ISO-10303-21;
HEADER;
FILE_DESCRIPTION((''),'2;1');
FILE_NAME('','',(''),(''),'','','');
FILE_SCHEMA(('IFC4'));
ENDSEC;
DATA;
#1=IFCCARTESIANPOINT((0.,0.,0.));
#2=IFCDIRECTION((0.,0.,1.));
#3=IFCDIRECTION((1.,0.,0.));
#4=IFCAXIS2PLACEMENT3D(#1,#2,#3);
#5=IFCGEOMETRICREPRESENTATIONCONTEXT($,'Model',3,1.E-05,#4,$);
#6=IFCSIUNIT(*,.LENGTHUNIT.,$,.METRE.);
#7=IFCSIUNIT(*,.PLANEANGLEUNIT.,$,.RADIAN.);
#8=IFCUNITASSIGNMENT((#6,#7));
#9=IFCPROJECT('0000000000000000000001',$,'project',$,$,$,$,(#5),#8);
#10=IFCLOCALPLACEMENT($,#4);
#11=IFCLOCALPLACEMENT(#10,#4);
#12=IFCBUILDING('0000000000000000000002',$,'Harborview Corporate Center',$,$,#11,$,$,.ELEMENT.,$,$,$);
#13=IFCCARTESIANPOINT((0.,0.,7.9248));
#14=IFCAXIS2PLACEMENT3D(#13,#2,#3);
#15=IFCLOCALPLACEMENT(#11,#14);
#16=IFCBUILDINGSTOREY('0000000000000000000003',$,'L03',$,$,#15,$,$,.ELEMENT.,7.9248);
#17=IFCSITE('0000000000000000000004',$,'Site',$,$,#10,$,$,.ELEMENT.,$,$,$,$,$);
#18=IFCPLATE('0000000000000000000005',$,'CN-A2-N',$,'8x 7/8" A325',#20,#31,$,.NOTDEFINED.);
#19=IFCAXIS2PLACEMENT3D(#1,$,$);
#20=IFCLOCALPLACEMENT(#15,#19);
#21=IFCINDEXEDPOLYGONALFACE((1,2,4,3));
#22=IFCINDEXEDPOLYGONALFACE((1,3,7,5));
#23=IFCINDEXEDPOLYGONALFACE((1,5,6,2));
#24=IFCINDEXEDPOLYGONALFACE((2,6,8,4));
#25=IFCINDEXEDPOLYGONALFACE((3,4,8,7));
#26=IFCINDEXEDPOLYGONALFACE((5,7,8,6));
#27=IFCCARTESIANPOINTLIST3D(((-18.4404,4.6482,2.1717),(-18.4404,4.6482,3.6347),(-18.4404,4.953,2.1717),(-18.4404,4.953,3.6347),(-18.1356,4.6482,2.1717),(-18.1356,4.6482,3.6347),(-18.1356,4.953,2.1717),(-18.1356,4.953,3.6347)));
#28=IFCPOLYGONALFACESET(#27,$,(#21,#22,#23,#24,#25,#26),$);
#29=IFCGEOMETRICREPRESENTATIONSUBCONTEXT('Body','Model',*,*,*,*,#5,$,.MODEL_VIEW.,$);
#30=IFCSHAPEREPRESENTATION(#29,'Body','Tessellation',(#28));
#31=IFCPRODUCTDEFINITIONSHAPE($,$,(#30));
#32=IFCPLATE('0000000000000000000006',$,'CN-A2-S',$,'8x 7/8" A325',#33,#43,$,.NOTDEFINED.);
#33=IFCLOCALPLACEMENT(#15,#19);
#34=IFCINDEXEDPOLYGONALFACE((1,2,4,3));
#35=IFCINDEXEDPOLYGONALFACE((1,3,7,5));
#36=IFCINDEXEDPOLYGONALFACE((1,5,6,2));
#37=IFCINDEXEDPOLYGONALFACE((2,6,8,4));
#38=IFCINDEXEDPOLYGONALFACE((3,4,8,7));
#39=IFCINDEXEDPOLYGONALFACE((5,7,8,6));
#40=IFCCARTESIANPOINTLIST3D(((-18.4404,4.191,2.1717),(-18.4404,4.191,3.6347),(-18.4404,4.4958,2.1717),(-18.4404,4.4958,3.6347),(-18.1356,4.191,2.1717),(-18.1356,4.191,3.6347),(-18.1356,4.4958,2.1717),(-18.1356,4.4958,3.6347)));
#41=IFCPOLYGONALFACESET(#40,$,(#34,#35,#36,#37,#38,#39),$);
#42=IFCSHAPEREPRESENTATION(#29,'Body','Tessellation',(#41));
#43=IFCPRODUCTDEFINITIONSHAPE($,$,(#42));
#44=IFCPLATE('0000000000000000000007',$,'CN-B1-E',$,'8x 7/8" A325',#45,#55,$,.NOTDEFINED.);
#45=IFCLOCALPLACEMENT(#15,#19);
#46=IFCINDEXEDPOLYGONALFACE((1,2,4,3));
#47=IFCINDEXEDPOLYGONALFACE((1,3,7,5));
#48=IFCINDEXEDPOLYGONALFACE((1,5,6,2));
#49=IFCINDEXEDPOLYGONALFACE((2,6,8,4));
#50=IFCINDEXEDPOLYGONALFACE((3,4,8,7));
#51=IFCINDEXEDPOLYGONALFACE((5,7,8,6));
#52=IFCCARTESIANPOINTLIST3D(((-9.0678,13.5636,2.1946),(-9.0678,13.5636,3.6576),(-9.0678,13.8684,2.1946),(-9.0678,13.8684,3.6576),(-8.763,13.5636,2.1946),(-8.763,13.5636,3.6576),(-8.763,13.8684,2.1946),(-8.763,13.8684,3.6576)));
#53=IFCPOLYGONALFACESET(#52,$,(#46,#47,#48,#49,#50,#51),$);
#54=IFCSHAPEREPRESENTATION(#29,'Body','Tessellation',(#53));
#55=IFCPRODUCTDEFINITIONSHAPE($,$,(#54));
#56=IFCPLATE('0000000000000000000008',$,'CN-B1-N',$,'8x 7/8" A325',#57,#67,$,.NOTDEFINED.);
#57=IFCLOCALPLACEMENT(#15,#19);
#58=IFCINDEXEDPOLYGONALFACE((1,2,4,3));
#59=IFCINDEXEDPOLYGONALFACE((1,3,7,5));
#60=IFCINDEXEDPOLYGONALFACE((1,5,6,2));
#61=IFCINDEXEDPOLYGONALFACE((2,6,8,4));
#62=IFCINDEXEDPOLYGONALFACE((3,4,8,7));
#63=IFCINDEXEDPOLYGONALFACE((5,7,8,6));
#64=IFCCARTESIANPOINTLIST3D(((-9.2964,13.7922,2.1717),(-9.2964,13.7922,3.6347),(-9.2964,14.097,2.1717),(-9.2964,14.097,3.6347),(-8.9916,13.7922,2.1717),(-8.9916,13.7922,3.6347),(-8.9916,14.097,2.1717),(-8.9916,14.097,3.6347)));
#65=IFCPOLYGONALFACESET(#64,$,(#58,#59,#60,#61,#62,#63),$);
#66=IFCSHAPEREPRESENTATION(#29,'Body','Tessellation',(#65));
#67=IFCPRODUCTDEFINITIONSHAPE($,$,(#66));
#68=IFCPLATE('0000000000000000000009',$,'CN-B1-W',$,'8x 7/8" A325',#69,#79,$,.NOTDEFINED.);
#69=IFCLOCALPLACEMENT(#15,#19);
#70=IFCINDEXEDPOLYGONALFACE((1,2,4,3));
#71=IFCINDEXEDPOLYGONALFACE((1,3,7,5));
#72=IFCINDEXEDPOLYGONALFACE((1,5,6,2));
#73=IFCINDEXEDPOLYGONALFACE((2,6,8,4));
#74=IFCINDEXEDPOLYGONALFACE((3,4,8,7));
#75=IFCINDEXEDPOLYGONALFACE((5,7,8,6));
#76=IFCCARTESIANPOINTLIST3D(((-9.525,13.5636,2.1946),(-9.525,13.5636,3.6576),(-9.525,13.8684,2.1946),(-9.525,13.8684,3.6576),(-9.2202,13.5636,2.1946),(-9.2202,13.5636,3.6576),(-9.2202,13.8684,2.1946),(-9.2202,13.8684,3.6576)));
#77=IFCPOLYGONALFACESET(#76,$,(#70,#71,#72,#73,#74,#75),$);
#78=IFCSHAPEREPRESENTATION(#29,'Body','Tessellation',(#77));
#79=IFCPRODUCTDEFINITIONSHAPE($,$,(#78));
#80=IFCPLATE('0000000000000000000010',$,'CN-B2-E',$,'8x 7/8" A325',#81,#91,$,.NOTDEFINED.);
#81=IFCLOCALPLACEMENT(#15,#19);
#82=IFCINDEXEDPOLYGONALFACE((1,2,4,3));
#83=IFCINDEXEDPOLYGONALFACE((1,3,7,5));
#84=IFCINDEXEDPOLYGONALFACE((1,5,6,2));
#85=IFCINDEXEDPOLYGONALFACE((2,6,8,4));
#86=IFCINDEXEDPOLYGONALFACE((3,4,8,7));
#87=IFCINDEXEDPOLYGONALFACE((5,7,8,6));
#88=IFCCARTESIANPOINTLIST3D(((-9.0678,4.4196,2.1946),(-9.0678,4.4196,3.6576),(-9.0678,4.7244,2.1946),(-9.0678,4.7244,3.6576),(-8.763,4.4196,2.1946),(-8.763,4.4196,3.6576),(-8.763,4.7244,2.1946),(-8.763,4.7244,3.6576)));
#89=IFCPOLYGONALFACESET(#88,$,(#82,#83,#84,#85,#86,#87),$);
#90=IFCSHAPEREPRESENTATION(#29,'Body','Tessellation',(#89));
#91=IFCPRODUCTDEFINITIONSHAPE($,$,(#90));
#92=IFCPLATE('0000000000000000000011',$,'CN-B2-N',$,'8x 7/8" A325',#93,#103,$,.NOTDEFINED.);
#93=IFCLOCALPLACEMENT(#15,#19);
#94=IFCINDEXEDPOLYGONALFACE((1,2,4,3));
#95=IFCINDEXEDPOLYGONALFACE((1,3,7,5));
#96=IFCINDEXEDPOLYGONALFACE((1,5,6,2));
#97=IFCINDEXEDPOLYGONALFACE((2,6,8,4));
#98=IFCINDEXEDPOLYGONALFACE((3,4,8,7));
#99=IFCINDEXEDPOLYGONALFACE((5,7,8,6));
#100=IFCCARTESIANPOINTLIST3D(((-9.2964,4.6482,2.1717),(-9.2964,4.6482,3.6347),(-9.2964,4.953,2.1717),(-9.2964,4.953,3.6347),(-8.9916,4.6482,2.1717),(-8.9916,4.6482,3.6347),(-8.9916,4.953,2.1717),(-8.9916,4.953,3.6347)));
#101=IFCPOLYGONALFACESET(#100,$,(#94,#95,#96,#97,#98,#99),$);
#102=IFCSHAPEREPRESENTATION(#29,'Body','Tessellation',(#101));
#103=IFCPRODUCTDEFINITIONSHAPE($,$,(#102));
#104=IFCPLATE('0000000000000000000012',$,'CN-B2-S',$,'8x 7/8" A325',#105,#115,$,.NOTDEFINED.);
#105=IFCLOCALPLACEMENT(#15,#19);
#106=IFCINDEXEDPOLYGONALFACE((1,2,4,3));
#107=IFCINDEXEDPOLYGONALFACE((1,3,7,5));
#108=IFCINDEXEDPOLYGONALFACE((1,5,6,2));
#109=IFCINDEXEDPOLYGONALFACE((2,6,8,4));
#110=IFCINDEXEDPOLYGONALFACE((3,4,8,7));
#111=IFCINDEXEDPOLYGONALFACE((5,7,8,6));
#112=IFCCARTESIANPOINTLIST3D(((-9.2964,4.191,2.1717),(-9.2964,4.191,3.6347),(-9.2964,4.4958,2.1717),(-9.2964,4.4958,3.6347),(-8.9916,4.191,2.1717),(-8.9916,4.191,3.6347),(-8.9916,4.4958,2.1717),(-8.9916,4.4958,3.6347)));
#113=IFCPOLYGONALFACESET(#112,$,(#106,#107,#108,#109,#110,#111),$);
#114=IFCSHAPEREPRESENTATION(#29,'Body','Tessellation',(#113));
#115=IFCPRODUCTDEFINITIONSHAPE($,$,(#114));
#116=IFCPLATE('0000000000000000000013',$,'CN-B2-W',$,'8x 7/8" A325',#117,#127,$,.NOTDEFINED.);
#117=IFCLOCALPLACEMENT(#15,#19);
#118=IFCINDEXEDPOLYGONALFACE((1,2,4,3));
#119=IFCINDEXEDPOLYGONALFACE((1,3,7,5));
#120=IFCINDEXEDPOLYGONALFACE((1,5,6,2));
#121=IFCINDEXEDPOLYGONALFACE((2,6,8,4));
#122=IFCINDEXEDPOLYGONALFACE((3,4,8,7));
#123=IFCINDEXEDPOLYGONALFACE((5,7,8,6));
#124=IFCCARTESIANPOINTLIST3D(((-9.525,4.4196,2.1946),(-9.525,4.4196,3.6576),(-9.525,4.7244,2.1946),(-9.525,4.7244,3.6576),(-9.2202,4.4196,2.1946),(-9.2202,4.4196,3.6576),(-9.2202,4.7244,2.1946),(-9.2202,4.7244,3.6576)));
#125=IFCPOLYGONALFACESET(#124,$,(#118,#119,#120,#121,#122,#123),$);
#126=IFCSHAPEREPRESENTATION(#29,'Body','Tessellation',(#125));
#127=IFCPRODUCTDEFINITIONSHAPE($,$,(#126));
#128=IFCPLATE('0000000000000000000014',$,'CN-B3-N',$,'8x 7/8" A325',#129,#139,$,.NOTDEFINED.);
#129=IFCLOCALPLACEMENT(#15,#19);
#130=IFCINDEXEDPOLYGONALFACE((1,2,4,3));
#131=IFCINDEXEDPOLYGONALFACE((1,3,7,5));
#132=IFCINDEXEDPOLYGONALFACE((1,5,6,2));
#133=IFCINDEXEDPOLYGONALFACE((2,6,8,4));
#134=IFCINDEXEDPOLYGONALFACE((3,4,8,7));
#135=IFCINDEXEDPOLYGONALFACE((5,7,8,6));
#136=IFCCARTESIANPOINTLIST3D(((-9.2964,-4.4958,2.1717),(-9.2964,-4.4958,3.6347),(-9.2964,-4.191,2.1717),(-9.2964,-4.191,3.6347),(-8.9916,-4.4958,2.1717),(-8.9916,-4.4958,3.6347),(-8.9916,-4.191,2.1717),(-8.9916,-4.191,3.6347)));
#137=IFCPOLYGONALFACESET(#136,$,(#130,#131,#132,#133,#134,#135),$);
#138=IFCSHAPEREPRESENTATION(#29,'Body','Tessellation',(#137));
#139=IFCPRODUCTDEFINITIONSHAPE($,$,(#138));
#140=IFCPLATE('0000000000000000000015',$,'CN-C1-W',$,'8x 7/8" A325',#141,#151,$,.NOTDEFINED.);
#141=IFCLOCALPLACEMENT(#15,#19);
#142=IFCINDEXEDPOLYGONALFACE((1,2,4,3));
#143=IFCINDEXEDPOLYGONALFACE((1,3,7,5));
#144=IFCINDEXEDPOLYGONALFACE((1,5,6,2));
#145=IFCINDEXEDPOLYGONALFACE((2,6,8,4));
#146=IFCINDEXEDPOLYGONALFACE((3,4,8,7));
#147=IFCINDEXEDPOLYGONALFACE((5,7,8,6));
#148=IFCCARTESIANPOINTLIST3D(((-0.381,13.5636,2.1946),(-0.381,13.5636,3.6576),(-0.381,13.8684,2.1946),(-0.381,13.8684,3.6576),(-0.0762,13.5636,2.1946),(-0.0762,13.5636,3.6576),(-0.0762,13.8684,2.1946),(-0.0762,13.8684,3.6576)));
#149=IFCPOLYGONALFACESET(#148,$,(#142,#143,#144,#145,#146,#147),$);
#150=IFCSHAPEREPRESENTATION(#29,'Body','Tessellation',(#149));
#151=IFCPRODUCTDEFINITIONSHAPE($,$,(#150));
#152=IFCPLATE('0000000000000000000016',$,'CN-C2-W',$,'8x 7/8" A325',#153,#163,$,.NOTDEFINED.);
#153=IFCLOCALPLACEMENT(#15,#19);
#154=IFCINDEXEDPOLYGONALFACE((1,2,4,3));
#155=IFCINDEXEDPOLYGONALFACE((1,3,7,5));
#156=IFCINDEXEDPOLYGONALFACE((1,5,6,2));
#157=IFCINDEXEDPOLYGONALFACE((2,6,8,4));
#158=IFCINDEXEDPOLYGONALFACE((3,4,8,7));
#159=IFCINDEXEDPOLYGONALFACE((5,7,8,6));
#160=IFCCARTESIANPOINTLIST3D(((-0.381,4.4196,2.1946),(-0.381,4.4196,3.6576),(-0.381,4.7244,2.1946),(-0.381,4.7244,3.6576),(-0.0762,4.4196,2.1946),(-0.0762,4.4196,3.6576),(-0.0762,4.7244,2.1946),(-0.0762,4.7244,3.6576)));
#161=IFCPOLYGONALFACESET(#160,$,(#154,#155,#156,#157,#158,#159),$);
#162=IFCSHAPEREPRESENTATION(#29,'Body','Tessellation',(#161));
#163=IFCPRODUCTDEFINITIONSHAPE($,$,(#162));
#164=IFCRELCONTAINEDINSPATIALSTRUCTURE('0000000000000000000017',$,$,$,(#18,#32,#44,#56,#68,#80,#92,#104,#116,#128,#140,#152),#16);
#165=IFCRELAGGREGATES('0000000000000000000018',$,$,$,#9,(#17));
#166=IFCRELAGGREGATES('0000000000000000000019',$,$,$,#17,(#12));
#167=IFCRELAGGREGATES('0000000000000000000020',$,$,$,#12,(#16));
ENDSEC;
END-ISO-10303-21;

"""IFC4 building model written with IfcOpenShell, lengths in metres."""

from ifc_helpers import new_model, si_unit, frame, origin_with_axes, place, context, subcontext, project, spatial, rectangle, extrude, element, save


model = new_model("IFC4")

# Units and contexts
model_context = context("Model", 3, precision=1e-05, world=origin_with_axes())
body_context = subcontext(model_context, "Body", "Model", "MODEL_VIEW")
ifc_project = project(units=[si_unit("LENGTHUNIT", "METRE"), si_unit("PLANEANGLEUNIT", "RADIAN")], contexts=[model_context])

# Site, building, storey
site_placement = place(None, origin_with_axes())
site = spatial("IfcSite", under=ifc_project, at=site_placement, Name="Site", CompositionType="ELEMENT")
building_placement = place(site_placement, origin_with_axes())
building = spatial("IfcBuilding", under=site, at=building_placement, Name="Harborview Corporate Center", CompositionType="ELEMENT")
storey_placement = place(building_placement, frame((0.0, 0.0, 7.9248), z_axis=(0.0, 0.0, 1.0), x_axis=(1.0, 0.0, 0.0)))
storey = spatial("IfcBuildingStorey", under=building, at=storey_placement, Name="L03", CompositionType="ELEMENT", Elevation=7.9248)

# Plates
for number, where, z_axis, x_axis, name in (
    (1, (-18.288, 4.8006, 2.1717), (0.0, 0.0, 1.0), (1.0, 0.0, 0.0), "CN-A2-N"),
    (2, (-18.288, 4.3434, 2.1717), (0.0, 0.0, 1.0), (1.0, 0.0, 0.0), "CN-A2-S"),
    (3, (-8.9154, 13.716, 2.1946), (0.0, 0.0, 1.0), (1.0, 0.0, 0.0), "CN-B1-E"),
    (4, (-9.144, 13.9446, 2.1717), (0.0, 0.0, 1.0), (1.0, 0.0, 0.0), "CN-B1-N"),
    (5, (-9.3726, 13.716, 2.1946), (0.0, 0.0, 1.0), (1.0, 0.0, 0.0), "CN-B1-W"),
    (6, (-8.9154, 4.572, 2.1946), (0.0, 0.0, 1.0), (1.0, 0.0, 0.0), "CN-B2-E"),
    (7, (-9.144, 4.8006, 2.1717), (0.0, 0.0, 1.0), (1.0, 0.0, 0.0), "CN-B2-N"),
    (8, (-9.144, 4.3434, 2.1717), (0.0, 0.0, 1.0), (1.0, 0.0, 0.0), "CN-B2-S"),
    (9, (-9.3726, 4.572, 2.1946), (0.0, 0.0, 1.0), (1.0, 0.0, 0.0), "CN-B2-W"),
    (10, (-9.144, -4.3434, 2.1717), (0.0, 0.0, 1.0), (1.0, 0.0, 0.0), "CN-B3-N"),
):
    element("IfcPlate", number, at=place(storey_placement, frame(where, z_axis=z_axis, x_axis=x_axis)), inside=storey, Name=name, ObjectType="8x 7/8\" A325", PredefinedType="NOTDEFINED", context=body_context, shape_type="SweptSolid", body=[
        extrude(rectangle(XDim=0.3048, YDim=0.3048), origin_with_axes(), (0.0, 0.0, 1.0), 1.463),
    ])
for number, where, z_axis, x_axis, name in (
    (11, (-0.2286, 13.716, 2.1946), (0.0, 0.0, 1.0), (1.0, 0.0, 0.0), "CN-C1-W"),
    (12, (-0.2286, 4.572, 2.1946), (0.0, 0.0, 1.0), (1.0, 0.0, 0.0), "CN-C2-W"),
):
    element("IfcPlate", number, at=place(storey_placement, frame(where, z_axis=z_axis, x_axis=x_axis)), inside=storey, Name=name, ObjectType="8x 7/8\" A325", PredefinedType="NOTDEFINED", context=body_context, shape_type="SweptSolid", body=[
        extrude(rectangle(XDim=0.3048, YDim=0.3048), origin_with_axes(), (0.0, 0.0, 1.0), 1.463),
    ])

save(model, "model.ifc")
